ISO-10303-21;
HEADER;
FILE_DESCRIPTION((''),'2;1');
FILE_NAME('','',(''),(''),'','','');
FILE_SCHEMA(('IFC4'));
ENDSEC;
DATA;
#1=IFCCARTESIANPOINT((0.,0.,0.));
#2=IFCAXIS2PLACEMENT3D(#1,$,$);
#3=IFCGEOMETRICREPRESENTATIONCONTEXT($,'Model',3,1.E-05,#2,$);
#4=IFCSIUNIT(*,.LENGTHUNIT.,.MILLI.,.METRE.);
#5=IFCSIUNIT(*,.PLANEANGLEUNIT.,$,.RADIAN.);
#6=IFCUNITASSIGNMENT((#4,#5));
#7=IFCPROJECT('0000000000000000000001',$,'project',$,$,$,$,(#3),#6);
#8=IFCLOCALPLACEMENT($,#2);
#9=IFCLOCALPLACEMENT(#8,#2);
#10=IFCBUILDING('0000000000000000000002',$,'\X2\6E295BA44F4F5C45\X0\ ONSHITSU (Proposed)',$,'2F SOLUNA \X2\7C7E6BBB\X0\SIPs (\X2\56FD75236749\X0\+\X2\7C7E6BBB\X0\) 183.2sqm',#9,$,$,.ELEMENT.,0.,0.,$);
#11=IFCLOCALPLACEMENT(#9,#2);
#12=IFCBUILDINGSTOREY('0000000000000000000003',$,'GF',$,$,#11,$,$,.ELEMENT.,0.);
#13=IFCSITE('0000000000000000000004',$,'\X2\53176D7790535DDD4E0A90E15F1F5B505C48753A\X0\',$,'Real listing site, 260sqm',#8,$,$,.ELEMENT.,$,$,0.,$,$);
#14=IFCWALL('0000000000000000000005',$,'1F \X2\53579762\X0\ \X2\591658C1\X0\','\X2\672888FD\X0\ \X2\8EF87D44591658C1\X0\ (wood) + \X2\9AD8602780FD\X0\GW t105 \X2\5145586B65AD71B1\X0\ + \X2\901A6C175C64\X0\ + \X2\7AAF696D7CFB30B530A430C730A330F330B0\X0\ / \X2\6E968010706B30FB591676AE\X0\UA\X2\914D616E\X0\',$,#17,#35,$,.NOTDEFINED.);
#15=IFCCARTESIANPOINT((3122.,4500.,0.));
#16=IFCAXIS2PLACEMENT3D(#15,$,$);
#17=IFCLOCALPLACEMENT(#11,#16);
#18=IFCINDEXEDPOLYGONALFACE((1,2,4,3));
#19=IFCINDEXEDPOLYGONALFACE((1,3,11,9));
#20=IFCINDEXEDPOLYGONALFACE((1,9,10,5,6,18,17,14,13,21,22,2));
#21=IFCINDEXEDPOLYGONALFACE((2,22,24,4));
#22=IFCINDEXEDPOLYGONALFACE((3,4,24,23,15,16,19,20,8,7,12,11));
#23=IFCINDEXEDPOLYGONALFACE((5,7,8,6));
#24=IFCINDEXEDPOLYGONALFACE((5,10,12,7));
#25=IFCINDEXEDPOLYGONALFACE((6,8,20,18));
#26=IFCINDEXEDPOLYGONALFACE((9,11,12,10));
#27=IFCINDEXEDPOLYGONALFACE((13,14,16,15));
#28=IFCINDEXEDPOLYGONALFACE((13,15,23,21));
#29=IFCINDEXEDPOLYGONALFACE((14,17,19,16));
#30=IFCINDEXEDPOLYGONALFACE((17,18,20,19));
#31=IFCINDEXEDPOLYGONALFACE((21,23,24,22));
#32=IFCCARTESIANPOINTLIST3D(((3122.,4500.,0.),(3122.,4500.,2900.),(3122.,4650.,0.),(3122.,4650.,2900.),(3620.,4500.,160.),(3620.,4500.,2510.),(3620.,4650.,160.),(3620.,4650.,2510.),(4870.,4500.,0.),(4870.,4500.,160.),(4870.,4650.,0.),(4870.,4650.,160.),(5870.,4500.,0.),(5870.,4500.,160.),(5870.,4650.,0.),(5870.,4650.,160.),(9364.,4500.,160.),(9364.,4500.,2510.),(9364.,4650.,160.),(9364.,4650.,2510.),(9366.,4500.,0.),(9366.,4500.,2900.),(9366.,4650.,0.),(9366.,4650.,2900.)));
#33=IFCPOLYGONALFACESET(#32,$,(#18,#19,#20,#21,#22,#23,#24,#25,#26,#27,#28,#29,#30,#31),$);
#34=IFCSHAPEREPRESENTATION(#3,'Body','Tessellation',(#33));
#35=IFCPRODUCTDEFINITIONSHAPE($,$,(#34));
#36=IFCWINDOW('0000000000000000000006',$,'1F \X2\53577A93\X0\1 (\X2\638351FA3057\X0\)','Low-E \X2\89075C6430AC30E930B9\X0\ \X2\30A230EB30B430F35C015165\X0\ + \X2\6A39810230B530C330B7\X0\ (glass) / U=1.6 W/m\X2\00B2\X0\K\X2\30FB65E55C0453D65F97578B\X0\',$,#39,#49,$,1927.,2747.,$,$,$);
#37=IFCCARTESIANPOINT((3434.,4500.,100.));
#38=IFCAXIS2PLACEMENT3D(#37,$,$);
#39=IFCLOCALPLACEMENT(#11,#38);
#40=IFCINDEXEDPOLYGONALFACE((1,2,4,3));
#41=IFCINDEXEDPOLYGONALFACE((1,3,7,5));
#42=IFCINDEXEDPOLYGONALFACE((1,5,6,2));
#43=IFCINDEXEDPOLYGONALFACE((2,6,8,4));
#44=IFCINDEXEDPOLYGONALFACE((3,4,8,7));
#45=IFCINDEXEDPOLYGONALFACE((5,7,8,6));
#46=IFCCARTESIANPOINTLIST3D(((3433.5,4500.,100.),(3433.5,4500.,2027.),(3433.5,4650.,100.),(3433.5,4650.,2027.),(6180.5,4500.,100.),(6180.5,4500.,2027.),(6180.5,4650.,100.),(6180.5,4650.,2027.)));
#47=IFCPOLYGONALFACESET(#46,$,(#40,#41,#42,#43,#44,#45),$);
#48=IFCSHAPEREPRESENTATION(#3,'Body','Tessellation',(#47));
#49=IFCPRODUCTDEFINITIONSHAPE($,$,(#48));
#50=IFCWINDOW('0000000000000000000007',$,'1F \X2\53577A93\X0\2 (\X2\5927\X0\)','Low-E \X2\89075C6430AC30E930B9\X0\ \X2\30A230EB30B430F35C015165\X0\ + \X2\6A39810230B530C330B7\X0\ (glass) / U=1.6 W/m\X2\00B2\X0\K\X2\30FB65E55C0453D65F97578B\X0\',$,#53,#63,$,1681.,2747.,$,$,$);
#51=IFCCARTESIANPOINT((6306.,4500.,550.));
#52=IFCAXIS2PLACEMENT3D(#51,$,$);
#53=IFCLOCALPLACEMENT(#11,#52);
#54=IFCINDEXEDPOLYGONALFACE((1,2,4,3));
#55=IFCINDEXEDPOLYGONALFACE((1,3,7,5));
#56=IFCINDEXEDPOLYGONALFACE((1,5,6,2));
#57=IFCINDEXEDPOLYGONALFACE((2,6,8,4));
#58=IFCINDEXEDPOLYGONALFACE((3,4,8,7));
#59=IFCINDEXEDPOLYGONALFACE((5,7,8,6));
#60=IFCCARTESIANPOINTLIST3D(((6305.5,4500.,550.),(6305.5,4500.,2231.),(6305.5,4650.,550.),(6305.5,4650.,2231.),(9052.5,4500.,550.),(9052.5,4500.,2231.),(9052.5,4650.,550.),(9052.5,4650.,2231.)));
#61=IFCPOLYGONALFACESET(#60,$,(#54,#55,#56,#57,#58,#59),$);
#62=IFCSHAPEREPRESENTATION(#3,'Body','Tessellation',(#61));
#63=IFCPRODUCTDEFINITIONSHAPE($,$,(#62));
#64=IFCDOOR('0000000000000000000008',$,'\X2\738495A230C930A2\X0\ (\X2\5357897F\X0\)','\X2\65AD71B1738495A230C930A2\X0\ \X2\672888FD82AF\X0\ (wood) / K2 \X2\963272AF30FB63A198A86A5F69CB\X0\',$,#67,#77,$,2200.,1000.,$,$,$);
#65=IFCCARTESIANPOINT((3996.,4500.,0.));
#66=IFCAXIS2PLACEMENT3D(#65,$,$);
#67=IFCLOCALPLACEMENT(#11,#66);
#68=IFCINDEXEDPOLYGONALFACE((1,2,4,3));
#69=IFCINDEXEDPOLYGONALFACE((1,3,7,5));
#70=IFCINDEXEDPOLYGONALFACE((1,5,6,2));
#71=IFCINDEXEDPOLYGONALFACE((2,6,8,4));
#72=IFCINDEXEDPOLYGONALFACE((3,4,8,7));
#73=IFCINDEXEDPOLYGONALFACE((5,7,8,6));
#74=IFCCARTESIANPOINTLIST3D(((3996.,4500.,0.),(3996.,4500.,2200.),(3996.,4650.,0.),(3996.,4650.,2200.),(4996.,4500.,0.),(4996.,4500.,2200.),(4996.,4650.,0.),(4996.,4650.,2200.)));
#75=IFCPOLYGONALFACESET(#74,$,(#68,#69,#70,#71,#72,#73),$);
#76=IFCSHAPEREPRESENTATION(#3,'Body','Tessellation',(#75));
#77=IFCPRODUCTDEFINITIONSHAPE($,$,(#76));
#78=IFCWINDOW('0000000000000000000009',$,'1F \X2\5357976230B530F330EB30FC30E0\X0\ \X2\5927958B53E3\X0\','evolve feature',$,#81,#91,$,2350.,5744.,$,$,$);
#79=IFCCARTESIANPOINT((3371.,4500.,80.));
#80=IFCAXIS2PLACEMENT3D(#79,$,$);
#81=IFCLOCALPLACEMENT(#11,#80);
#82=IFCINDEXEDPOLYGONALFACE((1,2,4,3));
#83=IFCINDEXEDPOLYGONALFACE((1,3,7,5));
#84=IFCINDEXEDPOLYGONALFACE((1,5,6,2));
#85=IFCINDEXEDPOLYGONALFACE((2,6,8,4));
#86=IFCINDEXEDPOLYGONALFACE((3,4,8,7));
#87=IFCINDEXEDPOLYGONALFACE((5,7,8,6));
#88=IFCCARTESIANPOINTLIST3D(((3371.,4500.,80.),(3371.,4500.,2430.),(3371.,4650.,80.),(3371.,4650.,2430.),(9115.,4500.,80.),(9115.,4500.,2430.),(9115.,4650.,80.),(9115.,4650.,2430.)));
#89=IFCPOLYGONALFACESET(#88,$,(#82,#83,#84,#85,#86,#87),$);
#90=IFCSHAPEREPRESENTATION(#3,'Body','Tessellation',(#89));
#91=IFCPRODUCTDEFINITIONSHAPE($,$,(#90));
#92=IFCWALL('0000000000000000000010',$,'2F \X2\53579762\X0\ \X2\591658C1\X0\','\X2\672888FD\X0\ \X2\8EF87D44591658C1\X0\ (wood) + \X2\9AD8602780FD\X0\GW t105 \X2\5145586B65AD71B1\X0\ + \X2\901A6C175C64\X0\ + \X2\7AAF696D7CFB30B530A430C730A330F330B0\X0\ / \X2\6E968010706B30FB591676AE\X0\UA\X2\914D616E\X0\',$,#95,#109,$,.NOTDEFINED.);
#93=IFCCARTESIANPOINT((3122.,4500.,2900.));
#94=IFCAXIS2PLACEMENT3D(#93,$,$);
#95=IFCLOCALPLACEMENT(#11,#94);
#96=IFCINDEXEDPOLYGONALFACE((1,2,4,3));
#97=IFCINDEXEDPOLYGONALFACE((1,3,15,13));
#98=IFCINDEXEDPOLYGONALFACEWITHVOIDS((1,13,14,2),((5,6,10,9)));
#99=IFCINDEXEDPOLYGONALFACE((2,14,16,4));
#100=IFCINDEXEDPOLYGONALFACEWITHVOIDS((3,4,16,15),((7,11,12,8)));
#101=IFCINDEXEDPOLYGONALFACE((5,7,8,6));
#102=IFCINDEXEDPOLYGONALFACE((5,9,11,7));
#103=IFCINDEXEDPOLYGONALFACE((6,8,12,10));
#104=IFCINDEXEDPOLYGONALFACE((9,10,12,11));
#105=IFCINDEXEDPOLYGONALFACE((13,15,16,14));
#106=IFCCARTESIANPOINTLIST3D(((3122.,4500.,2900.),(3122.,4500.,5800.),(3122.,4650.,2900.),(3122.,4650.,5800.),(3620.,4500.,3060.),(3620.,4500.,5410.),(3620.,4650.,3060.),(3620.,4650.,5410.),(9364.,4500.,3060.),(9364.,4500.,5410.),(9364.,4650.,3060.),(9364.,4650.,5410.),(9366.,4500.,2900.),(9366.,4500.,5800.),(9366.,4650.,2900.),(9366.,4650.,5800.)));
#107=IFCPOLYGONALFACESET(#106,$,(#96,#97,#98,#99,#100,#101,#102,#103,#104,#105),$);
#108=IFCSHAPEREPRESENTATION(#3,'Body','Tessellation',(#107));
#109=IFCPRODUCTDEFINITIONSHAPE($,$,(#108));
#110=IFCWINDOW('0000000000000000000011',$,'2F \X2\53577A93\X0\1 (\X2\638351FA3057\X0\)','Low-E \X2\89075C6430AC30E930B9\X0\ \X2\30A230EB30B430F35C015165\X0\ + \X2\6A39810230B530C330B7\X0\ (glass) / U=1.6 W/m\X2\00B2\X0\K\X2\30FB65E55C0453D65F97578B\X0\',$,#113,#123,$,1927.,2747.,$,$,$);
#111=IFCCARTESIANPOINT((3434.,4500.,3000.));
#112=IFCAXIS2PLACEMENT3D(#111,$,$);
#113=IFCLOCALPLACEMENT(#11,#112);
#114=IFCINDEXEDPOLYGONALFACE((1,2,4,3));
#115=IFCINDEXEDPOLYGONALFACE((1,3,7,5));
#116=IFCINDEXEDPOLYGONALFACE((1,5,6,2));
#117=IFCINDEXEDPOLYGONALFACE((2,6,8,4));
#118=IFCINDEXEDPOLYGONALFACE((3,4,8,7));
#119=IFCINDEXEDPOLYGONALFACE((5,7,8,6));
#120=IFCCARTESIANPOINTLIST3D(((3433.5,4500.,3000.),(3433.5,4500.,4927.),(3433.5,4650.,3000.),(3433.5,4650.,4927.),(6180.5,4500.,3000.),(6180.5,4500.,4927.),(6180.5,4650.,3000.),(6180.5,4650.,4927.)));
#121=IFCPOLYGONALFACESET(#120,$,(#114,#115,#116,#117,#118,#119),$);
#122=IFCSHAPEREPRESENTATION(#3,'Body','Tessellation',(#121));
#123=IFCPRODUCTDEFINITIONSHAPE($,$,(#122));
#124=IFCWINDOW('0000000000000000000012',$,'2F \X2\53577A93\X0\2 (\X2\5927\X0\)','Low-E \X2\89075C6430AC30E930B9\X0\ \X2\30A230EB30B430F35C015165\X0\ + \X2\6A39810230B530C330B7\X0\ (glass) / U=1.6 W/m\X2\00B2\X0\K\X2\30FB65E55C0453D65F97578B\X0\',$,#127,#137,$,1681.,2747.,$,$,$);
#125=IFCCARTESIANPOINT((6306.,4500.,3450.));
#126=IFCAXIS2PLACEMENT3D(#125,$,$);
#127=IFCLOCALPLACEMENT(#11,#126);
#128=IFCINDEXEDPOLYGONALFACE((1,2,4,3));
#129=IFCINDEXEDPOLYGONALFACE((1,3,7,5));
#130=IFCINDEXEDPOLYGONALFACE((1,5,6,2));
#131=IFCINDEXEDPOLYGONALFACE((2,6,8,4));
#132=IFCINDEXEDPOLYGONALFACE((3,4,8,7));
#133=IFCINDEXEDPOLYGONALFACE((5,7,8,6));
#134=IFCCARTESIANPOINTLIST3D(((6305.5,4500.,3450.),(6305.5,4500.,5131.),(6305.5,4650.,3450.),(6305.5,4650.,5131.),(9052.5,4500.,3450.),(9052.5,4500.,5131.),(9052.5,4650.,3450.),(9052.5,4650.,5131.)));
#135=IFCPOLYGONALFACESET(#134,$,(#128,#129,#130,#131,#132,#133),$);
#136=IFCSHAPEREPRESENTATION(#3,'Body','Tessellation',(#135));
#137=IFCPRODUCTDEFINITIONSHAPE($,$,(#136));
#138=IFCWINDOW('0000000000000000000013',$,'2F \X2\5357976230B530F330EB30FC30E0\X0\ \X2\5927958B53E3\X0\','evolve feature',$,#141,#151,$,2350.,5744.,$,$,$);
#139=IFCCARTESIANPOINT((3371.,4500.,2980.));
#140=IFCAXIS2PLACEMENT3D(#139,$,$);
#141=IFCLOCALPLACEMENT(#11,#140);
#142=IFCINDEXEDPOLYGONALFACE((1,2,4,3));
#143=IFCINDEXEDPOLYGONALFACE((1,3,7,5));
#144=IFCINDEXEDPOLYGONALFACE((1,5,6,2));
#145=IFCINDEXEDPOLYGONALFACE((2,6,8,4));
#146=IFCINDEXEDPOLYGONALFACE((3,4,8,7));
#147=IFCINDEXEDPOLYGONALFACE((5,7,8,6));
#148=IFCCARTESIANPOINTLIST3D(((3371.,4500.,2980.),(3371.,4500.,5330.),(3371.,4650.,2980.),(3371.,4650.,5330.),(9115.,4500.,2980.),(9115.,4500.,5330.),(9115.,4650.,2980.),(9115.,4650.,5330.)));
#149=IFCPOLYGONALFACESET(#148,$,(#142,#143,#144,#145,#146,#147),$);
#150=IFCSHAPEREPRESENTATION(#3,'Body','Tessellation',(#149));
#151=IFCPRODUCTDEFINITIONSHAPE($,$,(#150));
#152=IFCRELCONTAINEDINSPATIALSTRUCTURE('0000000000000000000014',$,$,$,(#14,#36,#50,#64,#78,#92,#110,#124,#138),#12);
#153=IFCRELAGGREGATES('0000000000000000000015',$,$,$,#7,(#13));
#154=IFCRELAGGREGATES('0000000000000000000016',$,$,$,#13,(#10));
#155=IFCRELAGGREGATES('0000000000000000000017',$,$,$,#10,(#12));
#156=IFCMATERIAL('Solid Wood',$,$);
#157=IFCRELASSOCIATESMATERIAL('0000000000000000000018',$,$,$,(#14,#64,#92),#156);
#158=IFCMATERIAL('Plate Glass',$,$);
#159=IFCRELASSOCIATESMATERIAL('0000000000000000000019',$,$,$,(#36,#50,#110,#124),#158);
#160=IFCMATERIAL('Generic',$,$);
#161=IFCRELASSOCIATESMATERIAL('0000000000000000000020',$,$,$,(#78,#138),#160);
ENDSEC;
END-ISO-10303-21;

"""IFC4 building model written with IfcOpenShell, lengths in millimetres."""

from ifc_helpers import new_model, si_unit, frame, frame_2d, origin, place, context, project, spatial, rectangle, extrude, material, element, fill, save


model = new_model("IFC4")

# Units and contexts
model_context = context("Model", 3, precision=1e-05, world=origin())
ifc_project = project(units=[si_unit("LENGTHUNIT", "METRE", prefix="MILLI"), si_unit("PLANEANGLEUNIT", "RADIAN")], contexts=[model_context])

# Site, building, storey
site_placement = place(None, origin())
site = spatial("IfcSite", under=ifc_project, at=site_placement, Name="北海道川上郡弟子屈町", ObjectType="Real listing site, 260sqm", CompositionType="ELEMENT", RefElevation=0.0)
building_placement = place(site_placement, origin())
building = spatial("IfcBuilding", under=site, at=building_placement, Name="温室住居 ONSHITSU (Proposed)", ObjectType="2F SOLUNA 籾殻SIPs (国産杉+籾殻) 183.2sqm", CompositionType="ELEMENT", ElevationOfRefHeight=0.0, ElevationOfTerrain=0.0)
storey_placement = place(building_placement, origin())
storey = spatial("IfcBuildingStorey", under=building, at=storey_placement, Name="GF", CompositionType="ELEMENT", Elevation=0.0)

# Shared definitions
ifc_material_1 = material(Name="Solid Wood")
ifc_material_2 = material(Name="Generic")

# Wall, openings, windows, door
wall_1_placement = place(storey_placement, frame((3122.0, 4500.0, 0.0)))
wall_1 = element("IfcWall", 1, at=wall_1_placement, inside=storey, material=ifc_material_1, Name="1F 南面 外壁", Description="木製 軸組外壁 (wood) + 高性能GW t105 充填断熱 + 通気層 + 窯業系サイディング / 準耐火・外皮UA配慮", PredefinedType="NOTDEFINED", context=model_context, shape_type="SweptSolid", body=[
    extrude(rectangle(XDim=6244.0, YDim=150.0, at=frame_2d((3122.0, 75.0))), frame((3122.0, 4500.0, 0.0)), (0.0, 0.0, 1.0), 2900.0),
])
opening_1_placement = place(storey_placement, frame((3434.0, 4500.0, 100.0)))
opening_1 = element("IfcOpeningElement", 2, at=opening_1_placement, cuts=wall_1, PredefinedType="NOTDEFINED", context=model_context, shape_type="SweptSolid", body=[
    extrude(rectangle(XDim=2747.0, YDim=150.0, at=frame_2d((1373.0, 75.0))), frame((3434.0, 4500.0, 100.0)), (0.0, 0.0, 1.0), 1927.0),
])
opening_2_placement = place(storey_placement, frame((6306.0, 4500.0, 550.0)))
opening_2 = element("IfcOpeningElement", 3, at=opening_2_placement, cuts=wall_1, PredefinedType="NOTDEFINED", context=model_context, shape_type="SweptSolid", body=[
    extrude(rectangle(XDim=2747.0, YDim=150.0, at=frame_2d((1373.0, 75.0))), frame((6306.0, 4500.0, 550.0)), (0.0, 0.0, 1.0), 1681.0),
])
opening_3_placement = place(storey_placement, frame((3996.0, 4500.0, 0.0)))
opening_3 = element("IfcOpeningElement", 4, at=opening_3_placement, cuts=wall_1, PredefinedType="NOTDEFINED", context=model_context, shape_type="SweptSolid", body=[
    extrude(rectangle(XDim=1000.0, YDim=150.0, at=frame_2d((500.0, 75.0))), frame((3996.0, 4500.0, 0.0)), (0.0, 0.0, 1.0), 2200.0),
])
opening_4_placement = place(storey_placement, frame((3371.0, 4500.0, 80.0)))
opening_4 = element("IfcOpeningElement", 5, at=opening_4_placement, cuts=wall_1, PredefinedType="NOTDEFINED", context=model_context, shape_type="SweptSolid", body=[
    extrude(rectangle(XDim=5744.0, YDim=150.0, at=frame_2d((2872.0, 75.0))), frame((3371.0, 4500.0, 80.0)), (0.0, 0.0, 1.0), 2350.0),
])
ifc_material_3 = material(Name="Plate Glass")
window_1_placement = place(storey_placement, frame((3434.0, 4500.0, 100.0)))
window_1 = element("IfcWindow", 6, at=window_1_placement, inside=storey, material=ifc_material_3, Name="1F 南窓1 (掃出し)", Description="Low-E 複層ガラス アルゴン封入 + 樹脂サッシ (glass) / U=1.6 W/m²K・日射取得型", OverallHeight=1927.0, OverallWidth=2747.0, context=model_context, shape_type="SweptSolid", body=[
    extrude(rectangle(XDim=2747.0, YDim=150.0, at=frame_2d((1373.0, 75.0))), frame((3434.0, 4500.0, 100.0)), (0.0, 0.0, 1.0), 1927.0),
])
fill(opening_1, window_1)
window_2_placement = place(storey_placement, frame((6306.0, 4500.0, 550.0)))
window_2 = element("IfcWindow", 7, at=window_2_placement, inside=storey, material=ifc_material_3, Name="1F 南窓2 (大)", Description="Low-E 複層ガラス アルゴン封入 + 樹脂サッシ (glass) / U=1.6 W/m²K・日射取得型", OverallHeight=1681.0, OverallWidth=2747.0, context=model_context, shape_type="SweptSolid", body=[
    extrude(rectangle(XDim=2747.0, YDim=150.0, at=frame_2d((1373.0, 75.0))), frame((6306.0, 4500.0, 550.0)), (0.0, 0.0, 1.0), 1681.0),
])
fill(opening_2, window_2)
door_placement = place(storey_placement, frame((3996.0, 4500.0, 0.0)))
door = element("IfcDoor", 8, at=door_placement, inside=storey, material=ifc_material_1, Name="玄関ドア (南西)", Description="断熱玄関ドア 木製芯 (wood) / K2 防犯・採風機構", OverallHeight=2200.0, OverallWidth=1000.0, context=model_context, shape_type="SweptSolid", body=[
    extrude(rectangle(XDim=1000.0, YDim=150.0, at=frame_2d((500.0, 75.0))), frame((3996.0, 4500.0, 0.0)), (0.0, 0.0, 1.0), 2200.0),
])
fill(opening_3, door)
window_3_placement = place(storey_placement, frame((3371.0, 4500.0, 80.0)))
window_3 = element("IfcWindow", 9, at=window_3_placement, inside=storey, material=ifc_material_2, Name="1F 南面サンルーム 大開口", Description="evolve feature", OverallHeight=2350.0, OverallWidth=5744.0, context=model_context, shape_type="SweptSolid", body=[
    extrude(rectangle(XDim=5744.0, YDim=150.0, at=frame_2d((2872.0, 75.0))), frame((3371.0, 4500.0, 80.0)), (0.0, 0.0, 1.0), 2350.0),
])
fill(opening_4, window_3)

# Wall, openings, windows
wall_2_placement = place(storey_placement, frame((3122.0, 4500.0, 2900.0)))
wall_2 = element("IfcWall", 10, at=wall_2_placement, inside=storey, material=ifc_material_1, Name="2F 南面 外壁", Description="木製 軸組外壁 (wood) + 高性能GW t105 充填断熱 + 通気層 + 窯業系サイディング / 準耐火・外皮UA配慮", PredefinedType="NOTDEFINED", context=model_context, shape_type="SweptSolid", body=[
    extrude(rectangle(XDim=6244.0, YDim=150.0, at=frame_2d((3122.0, 75.0))), frame((3122.0, 4500.0, 2900.0)), (0.0, 0.0, 1.0), 2900.0),
])
opening_5_placement = place(storey_placement, frame((3434.0, 4500.0, 3000.0)))
opening_5 = element("IfcOpeningElement", 11, at=opening_5_placement, cuts=wall_2, PredefinedType="NOTDEFINED", context=model_context, shape_type="SweptSolid", body=[
    extrude(rectangle(XDim=2747.0, YDim=150.0, at=frame_2d((1373.0, 75.0))), frame((3434.0, 4500.0, 3000.0)), (0.0, 0.0, 1.0), 1927.0),
])
opening_6_placement = place(storey_placement, frame((6306.0, 4500.0, 3450.0)))
opening_6 = element("IfcOpeningElement", 12, at=opening_6_placement, cuts=wall_2, PredefinedType="NOTDEFINED", context=model_context, shape_type="SweptSolid", body=[
    extrude(rectangle(XDim=2747.0, YDim=150.0, at=frame_2d((1373.0, 75.0))), frame((6306.0, 4500.0, 3450.0)), (0.0, 0.0, 1.0), 1681.0),
])
opening_7_placement = place(storey_placement, frame((3371.0, 4500.0, 2980.0)))
opening_7 = element("IfcOpeningElement", 13, at=opening_7_placement, cuts=wall_2, PredefinedType="NOTDEFINED", context=model_context, shape_type="SweptSolid", body=[
    extrude(rectangle(XDim=5744.0, YDim=150.0, at=frame_2d((2872.0, 75.0))), frame((3371.0, 4500.0, 2980.0)), (0.0, 0.0, 1.0), 2350.0),
])
window_4_placement = place(storey_placement, frame((3434.0, 4500.0, 3000.0)))
window_4 = element("IfcWindow", 14, at=window_4_placement, inside=storey, material=ifc_material_3, Name="2F 南窓1 (掃出し)", Description="Low-E 複層ガラス アルゴン封入 + 樹脂サッシ (glass) / U=1.6 W/m²K・日射取得型", OverallHeight=1927.0, OverallWidth=2747.0, context=model_context, shape_type="SweptSolid", body=[
    extrude(rectangle(XDim=2747.0, YDim=150.0, at=frame_2d((1373.0, 75.0))), frame((3434.0, 4500.0, 3000.0)), (0.0, 0.0, 1.0), 1927.0),
])
fill(opening_5, window_4)
window_5_placement = place(storey_placement, frame((6306.0, 4500.0, 3450.0)))
window_5 = element("IfcWindow", 15, at=window_5_placement, inside=storey, material=ifc_material_3, Name="2F 南窓2 (大)", Description="Low-E 複層ガラス アルゴン封入 + 樹脂サッシ (glass) / U=1.6 W/m²K・日射取得型", OverallHeight=1681.0, OverallWidth=2747.0, context=model_context, shape_type="SweptSolid", body=[
    extrude(rectangle(XDim=2747.0, YDim=150.0, at=frame_2d((1373.0, 75.0))), frame((6306.0, 4500.0, 3450.0)), (0.0, 0.0, 1.0), 1681.0),
])
fill(opening_6, window_5)
window_6_placement = place(storey_placement, frame((3371.0, 4500.0, 2980.0)))
window_6 = element("IfcWindow", 16, at=window_6_placement, inside=storey, material=ifc_material_2, Name="2F 南面サンルーム 大開口", Description="evolve feature", OverallHeight=2350.0, OverallWidth=5744.0, context=model_context, shape_type="SweptSolid", body=[
    extrude(rectangle(XDim=5744.0, YDim=150.0, at=frame_2d((2872.0, 75.0))), frame((3371.0, 4500.0, 2980.0)), (0.0, 0.0, 1.0), 2350.0),
])
fill(opening_7, window_6)

save(model, "model.ifc")
